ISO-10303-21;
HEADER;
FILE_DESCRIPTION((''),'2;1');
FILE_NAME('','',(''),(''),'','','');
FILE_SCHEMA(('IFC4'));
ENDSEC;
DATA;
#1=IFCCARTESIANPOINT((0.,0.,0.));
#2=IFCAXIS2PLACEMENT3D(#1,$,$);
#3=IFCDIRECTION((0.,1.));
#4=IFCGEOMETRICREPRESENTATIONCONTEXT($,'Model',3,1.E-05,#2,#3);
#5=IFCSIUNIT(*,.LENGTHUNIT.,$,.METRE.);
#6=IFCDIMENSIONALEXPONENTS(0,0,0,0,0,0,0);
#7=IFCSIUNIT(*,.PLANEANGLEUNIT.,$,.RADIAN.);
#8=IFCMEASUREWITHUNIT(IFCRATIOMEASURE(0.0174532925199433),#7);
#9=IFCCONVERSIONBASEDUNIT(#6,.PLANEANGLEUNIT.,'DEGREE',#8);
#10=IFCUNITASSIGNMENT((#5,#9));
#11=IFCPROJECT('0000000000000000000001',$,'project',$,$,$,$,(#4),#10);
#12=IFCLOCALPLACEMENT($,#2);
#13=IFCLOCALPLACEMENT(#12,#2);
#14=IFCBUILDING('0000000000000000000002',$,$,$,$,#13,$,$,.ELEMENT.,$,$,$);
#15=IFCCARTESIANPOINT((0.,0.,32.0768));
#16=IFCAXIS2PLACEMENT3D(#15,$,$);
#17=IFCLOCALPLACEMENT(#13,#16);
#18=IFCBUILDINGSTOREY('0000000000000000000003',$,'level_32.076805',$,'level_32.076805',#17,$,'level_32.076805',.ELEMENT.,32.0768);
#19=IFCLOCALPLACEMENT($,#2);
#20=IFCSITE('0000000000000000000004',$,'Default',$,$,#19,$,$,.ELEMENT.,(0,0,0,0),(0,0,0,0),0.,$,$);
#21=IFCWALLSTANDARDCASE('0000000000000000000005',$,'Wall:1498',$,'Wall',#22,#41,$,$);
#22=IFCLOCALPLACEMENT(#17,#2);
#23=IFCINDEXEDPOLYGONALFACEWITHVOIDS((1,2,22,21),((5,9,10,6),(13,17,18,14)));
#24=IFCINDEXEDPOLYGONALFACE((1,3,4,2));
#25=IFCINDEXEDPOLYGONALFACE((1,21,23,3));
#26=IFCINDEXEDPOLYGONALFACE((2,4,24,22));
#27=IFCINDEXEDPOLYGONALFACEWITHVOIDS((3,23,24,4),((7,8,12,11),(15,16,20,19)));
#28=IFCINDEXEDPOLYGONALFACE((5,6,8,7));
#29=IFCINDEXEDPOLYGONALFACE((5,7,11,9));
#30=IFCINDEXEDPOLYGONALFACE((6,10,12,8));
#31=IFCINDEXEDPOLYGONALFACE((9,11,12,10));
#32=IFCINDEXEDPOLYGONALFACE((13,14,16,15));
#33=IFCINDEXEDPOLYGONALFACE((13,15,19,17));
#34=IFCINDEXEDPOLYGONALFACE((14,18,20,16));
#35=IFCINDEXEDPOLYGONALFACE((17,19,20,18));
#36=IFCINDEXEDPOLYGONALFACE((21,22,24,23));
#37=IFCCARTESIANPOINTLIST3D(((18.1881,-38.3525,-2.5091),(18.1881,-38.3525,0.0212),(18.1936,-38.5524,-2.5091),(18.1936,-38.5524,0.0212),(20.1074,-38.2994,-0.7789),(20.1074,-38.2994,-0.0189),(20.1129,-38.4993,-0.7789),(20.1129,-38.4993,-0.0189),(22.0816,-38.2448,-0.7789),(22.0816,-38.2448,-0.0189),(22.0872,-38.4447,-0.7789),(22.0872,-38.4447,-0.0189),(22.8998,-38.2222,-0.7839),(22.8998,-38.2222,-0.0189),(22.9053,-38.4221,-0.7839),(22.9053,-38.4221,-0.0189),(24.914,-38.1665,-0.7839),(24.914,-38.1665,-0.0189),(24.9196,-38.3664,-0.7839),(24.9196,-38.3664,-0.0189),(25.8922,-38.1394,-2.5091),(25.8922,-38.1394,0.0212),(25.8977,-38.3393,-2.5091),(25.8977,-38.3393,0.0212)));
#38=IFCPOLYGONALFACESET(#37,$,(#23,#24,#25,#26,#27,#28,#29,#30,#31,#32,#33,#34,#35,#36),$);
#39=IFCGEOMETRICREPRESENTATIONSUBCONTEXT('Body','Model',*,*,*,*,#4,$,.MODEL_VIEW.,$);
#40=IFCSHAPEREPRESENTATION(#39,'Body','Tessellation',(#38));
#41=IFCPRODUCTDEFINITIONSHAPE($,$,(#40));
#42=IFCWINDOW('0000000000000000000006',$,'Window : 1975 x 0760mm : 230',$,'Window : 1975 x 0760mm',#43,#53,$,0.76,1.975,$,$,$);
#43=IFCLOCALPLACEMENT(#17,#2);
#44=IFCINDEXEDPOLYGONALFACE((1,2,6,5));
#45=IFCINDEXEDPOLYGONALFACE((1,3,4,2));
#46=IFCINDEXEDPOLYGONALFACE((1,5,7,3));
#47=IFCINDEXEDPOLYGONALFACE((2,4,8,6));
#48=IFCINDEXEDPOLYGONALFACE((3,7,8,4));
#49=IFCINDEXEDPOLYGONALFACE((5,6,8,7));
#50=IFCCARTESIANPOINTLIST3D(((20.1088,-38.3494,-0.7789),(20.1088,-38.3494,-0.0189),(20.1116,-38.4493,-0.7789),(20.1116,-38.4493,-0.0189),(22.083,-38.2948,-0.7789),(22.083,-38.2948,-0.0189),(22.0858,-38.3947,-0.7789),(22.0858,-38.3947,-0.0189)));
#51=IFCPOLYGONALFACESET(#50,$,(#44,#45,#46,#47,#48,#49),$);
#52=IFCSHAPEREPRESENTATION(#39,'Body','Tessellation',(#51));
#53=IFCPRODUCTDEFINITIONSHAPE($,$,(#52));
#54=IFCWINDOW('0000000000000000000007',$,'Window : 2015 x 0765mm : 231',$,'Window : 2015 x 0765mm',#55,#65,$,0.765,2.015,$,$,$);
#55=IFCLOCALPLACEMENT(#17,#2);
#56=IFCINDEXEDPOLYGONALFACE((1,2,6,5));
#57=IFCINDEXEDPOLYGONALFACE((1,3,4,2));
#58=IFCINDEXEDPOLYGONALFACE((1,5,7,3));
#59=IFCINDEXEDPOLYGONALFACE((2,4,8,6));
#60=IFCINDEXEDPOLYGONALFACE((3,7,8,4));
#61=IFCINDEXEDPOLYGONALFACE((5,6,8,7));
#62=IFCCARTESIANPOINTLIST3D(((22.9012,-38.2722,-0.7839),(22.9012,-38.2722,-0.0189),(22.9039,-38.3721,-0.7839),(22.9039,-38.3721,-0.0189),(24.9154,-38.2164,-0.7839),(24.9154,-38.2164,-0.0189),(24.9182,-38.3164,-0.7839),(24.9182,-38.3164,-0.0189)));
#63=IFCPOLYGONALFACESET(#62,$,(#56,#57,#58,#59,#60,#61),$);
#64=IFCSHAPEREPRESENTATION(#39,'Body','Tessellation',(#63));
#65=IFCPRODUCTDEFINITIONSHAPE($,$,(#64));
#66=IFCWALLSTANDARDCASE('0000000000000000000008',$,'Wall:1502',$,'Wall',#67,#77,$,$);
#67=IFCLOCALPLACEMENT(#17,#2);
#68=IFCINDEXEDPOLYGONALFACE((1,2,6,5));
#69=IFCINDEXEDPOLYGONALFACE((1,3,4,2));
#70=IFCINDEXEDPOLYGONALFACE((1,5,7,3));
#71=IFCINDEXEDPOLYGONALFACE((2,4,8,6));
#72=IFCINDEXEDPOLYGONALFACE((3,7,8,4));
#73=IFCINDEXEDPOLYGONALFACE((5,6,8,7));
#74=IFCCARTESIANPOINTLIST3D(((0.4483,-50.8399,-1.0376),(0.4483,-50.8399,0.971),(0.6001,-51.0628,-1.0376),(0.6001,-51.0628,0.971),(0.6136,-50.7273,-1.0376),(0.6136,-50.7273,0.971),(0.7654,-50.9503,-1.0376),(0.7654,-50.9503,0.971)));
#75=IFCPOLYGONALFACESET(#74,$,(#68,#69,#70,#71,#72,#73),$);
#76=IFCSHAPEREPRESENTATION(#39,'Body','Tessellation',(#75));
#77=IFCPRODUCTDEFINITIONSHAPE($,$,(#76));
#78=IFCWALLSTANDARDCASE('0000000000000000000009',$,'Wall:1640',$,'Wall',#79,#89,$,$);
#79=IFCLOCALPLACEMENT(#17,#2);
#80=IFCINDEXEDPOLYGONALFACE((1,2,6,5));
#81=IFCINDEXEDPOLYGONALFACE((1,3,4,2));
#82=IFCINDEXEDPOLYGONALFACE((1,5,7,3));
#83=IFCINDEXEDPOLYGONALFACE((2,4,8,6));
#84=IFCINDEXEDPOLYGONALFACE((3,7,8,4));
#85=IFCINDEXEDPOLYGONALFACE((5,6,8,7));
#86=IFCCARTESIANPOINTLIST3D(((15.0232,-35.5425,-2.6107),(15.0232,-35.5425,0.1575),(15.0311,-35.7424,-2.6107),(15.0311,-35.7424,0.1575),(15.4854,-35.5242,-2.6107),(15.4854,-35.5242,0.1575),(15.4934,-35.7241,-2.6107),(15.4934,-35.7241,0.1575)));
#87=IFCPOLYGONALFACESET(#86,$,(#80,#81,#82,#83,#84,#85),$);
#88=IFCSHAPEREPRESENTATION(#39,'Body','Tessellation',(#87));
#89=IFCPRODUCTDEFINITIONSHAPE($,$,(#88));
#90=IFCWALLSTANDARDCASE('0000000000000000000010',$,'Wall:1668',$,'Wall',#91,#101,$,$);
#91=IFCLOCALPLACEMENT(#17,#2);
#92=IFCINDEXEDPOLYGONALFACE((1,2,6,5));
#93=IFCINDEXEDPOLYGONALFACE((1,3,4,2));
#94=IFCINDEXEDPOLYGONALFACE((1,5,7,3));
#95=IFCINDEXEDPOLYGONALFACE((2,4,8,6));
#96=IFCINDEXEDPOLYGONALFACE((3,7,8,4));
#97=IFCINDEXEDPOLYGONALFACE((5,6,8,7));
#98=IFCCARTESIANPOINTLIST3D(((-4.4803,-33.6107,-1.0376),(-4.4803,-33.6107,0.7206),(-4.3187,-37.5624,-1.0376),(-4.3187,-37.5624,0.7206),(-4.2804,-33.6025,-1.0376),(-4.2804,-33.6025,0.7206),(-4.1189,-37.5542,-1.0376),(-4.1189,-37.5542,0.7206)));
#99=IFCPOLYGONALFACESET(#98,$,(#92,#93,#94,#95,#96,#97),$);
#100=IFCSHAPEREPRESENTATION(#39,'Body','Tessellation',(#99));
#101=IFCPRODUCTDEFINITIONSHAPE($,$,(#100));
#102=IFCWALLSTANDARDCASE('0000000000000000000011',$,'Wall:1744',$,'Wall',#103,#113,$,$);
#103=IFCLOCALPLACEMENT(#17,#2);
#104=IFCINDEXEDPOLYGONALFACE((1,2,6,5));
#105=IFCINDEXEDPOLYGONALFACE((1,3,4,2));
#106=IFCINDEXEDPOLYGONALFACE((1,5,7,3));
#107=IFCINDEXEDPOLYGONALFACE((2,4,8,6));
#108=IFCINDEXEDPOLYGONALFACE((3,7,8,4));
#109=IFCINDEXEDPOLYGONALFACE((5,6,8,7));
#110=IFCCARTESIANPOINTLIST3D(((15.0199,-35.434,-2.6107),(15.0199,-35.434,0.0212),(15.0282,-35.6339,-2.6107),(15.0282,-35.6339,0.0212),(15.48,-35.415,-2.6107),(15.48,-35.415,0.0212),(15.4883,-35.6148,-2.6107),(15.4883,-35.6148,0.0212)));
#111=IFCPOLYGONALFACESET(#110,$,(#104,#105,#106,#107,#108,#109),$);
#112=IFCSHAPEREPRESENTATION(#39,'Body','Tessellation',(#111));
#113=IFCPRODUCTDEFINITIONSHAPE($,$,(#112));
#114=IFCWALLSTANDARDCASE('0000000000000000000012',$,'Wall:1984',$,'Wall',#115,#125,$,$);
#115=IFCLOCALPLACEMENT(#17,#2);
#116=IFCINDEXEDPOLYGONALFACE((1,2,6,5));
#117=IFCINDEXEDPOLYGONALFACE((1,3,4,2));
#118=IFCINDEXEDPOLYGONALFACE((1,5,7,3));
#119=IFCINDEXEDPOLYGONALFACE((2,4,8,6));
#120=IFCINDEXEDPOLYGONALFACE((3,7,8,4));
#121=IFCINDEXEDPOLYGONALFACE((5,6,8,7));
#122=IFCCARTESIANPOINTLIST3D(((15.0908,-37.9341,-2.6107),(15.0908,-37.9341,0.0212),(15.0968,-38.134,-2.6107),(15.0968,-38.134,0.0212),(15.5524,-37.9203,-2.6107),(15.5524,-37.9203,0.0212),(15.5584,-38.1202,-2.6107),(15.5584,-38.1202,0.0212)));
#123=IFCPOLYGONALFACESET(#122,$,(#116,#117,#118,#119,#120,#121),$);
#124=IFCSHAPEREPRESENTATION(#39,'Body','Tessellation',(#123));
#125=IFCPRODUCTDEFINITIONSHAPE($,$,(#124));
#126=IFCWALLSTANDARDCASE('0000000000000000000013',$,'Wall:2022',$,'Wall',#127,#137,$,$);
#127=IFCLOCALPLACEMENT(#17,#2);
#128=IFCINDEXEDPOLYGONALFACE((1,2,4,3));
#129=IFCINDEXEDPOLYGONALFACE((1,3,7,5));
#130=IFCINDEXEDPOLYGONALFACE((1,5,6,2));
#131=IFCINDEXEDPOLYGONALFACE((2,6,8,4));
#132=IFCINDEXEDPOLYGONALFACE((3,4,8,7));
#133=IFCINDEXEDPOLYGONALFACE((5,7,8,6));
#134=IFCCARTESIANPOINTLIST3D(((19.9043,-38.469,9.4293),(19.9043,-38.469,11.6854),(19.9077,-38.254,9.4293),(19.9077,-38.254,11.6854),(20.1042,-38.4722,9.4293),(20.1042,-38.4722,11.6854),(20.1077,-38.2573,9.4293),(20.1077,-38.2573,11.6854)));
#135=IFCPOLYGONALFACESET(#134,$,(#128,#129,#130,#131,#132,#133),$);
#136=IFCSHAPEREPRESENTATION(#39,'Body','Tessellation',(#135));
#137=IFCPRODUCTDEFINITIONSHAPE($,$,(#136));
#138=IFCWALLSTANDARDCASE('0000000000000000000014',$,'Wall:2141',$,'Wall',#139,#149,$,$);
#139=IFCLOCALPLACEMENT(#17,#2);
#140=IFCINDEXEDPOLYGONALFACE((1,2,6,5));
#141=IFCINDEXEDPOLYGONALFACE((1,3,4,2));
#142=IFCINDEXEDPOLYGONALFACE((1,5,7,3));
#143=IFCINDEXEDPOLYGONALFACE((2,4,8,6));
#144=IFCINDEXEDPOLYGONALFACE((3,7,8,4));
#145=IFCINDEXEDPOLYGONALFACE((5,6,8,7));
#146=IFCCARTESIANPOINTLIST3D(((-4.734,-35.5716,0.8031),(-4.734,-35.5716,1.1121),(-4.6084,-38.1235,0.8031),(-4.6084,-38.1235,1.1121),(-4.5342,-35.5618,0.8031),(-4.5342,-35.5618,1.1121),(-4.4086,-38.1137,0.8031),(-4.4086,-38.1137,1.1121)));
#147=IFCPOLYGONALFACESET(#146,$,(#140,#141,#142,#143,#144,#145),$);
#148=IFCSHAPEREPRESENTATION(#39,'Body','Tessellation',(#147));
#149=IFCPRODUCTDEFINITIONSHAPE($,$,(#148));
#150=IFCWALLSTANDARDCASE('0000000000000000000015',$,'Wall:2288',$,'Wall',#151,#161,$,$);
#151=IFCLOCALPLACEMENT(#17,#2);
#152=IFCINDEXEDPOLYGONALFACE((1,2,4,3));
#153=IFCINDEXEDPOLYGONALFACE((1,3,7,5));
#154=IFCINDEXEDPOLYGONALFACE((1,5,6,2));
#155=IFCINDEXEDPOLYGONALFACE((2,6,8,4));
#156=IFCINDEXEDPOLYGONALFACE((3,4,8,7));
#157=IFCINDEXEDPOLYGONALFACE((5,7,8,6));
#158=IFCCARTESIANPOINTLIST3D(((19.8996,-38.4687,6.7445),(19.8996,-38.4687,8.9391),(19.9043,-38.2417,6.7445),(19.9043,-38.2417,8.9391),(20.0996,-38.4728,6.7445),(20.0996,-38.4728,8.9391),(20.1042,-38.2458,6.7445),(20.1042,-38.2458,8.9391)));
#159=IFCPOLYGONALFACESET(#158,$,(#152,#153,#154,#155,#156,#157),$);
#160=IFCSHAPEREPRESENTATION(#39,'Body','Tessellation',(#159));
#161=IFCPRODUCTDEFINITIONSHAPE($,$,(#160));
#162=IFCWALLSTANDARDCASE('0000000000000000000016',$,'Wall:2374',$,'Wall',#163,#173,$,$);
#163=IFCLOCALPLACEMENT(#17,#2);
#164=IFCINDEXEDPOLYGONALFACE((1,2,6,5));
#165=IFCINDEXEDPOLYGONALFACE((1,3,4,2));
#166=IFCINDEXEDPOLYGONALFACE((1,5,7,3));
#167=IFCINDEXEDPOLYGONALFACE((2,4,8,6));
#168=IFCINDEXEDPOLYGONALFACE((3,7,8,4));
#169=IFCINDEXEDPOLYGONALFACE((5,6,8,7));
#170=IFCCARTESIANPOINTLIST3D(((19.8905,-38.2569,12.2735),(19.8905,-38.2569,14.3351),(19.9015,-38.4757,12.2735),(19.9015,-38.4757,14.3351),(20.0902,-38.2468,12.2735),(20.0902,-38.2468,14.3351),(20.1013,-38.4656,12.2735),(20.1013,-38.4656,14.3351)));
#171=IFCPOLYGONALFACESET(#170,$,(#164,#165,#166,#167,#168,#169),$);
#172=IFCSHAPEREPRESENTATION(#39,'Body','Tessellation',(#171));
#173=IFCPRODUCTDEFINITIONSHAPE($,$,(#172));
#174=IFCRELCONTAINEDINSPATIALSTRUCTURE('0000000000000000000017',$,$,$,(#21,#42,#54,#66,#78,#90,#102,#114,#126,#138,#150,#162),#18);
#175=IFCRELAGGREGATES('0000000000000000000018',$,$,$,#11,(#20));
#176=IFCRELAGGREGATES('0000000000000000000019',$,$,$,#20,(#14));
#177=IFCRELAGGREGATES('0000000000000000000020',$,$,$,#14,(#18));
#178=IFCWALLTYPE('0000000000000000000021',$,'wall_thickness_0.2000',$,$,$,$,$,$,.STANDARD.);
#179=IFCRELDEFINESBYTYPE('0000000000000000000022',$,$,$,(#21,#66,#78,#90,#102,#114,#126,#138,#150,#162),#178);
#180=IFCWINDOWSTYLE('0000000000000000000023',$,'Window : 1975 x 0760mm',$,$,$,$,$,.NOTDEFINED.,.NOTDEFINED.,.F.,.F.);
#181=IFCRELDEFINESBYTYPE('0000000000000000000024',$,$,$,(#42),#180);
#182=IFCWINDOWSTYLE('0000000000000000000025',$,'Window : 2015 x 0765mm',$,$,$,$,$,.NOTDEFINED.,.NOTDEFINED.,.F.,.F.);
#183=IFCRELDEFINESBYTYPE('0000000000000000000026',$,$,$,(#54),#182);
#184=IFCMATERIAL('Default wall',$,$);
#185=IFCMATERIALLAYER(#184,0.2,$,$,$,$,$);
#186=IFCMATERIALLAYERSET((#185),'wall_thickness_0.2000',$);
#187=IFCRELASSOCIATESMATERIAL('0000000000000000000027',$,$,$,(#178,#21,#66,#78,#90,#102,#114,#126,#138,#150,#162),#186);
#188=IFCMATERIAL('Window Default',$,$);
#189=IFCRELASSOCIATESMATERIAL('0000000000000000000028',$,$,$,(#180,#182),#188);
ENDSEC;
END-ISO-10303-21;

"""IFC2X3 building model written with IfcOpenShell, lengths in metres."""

from ifc_helpers import new_model, entity, si_unit, converted_unit, direction, frame, frame_2d, origin, origin_2d_with_axis, place, context, subcontext, project, spatial, polyline, rectangle, outline, extrude, source, transform, mapped, material, layer, layer_set, layer_usage, type_object, type_shapes, element, fill, save


model = new_model("IFC2X3")

# Units and contexts
model_context = context("Model", 3, precision=1e-05, world=origin(), true_north=direction((0.0, 1.0)))
body_context = subcontext(model_context, "Body", "Model", "MODEL_VIEW")
ifc_project = project(units=[si_unit("LENGTHUNIT", "METRE"), converted_unit("PLANEANGLEUNIT", "DEGREE", entity("IfcRatioMeasure", 0.0174532925199433), si_unit("PLANEANGLEUNIT", "RADIAN"), dimensions=[0, 0, 0, 0, 0, 0, 0])], contexts=[model_context])

# Site, building, storey
site_placement = place(None, origin())
site = spatial("IfcSite", under=ifc_project, at=site_placement, Name="Default", CompositionType="ELEMENT", RefLatitude=(0, 0, 0, 0), RefLongitude=(0, 0, 0, 0), RefElevation=0.0)
placement_1 = place(None, origin())
building_placement = place(placement_1, origin())
building = spatial("IfcBuilding", under=site, at=building_placement, CompositionType="ELEMENT")
storey_placement = place(building_placement, frame((0.0, 0.0, 32.0768)))
storey = spatial("IfcBuildingStorey", under=building, at=storey_placement, Name="level_32.076805", ObjectType="level_32.076805", LongName="level_32.076805", CompositionType="ELEMENT", Elevation=32.0768)

# Shared definitions
ifc_material_1 = material(Name="Default wall")
ifc_layer = layer(ifc_material_1, 0.2)
ifc_layer_set = layer_set([ifc_layer], Name="wall_thickness_0.2000")
ifc_layer_usage = layer_usage(ifc_layer_set, "AXIS2", "POSITIVE", -0.1)
wall_type = type_object("IfcWallType", Name="wall_thickness_0.2000", PredefinedType="STANDARD", material=ifc_layer_set)

# Shared definitions
ifc_material_2 = material(Name="Window Default")

# Wall, openings, windows
placement_2 = place(building_placement, frame((0.0, 0.0, 29.5677)))
wall_1_placement = place(placement_2, frame((18.1909, -38.4525, 0.0), z_axis=(0.0, 0.0, 1.0), x_axis=(0.999618, 0.027649, 0.0)))
wall_1 = element("IfcWallStandardCase", 1, at=wall_1_placement, inside=storey, type_object=wall_type, material=ifc_layer_usage, Name="Wall:1498", ObjectType="Wall", context=body_context, shape_type="SweptSolid", body=[
    extrude(outline(polyline([(7.707, -0.1), (7.707, 0.1), (0.0, 0.1), (0.0, -0.1), (7.707, -0.1)])), origin(), (0.0, 0.0, 1.0), 2.5303),
])
opening_1_placement = place(wall_1_placement, frame((1.92, -0.1, 1.7302)))
opening_1 = element("IfcOpeningElement", 2, at=opening_1_placement, cuts=wall_1, ObjectType="Opening", context=body_context, shape_type="SweptSolid", body=[
    extrude(rectangle(XDim=1.975, YDim=0.76, at=frame_2d((0.38, 0.9875), x_axis=(0.0, 1.0))), frame((0.0, 0.0, 0.0), z_axis=(0.0, 1.0, 0.0), x_axis=(0.0, 0.0, 1.0)), (0.0, 0.0, 1.0), 0.2),
])
opening_2_placement = place(wall_1_placement, frame((4.7135, -0.1, 1.7252)))
opening_2 = element("IfcOpeningElement", 3, at=opening_2_placement, cuts=wall_1, ObjectType="Opening", context=body_context, shape_type="SweptSolid", body=[
    extrude(rectangle(XDim=2.015, YDim=0.765, at=frame_2d((0.3825, 1.0075), x_axis=(0.0, 1.0))), frame((0.0, 0.0, 0.0), z_axis=(0.0, 1.0, 0.0), x_axis=(0.0, 0.0, 1.0)), (0.0, 0.0, 1.0), 0.2),
])
window_style_1 = type_object("IfcWindowStyle", Name="Window : 1975 x 0760mm", ConstructionType="NOTDEFINED", OperationType="NOTDEFINED", ParameterTakesPrecedence=False, Sizeable=False, material=ifc_material_2)
shared_shape_1 = source(origin(), body_context, "Body", "SweptSolid", [
    extrude(rectangle(XDim=0.1, YDim=1.975, at=origin_2d_with_axis()), frame((0.9875, 0.1, 0.0), z_axis=(0.0, 0.0, 1.0), x_axis=(0.0, 1.0, 0.0)), (0.0, 0.0, 1.0), 0.76),
])
type_shapes(window_style_1, [shared_shape_1])
window_1_placement = place(opening_1_placement, origin())
window_1 = element("IfcWindow", 4, at=window_1_placement, inside=storey, type_object=window_style_1, Name="Window : 1975 x 0760mm : 230", ObjectType="Window : 1975 x 0760mm", OverallHeight=0.76, OverallWidth=1.975, context=body_context, shape_type="MappedRepresentation", body=[
    mapped(shared_shape_1, transform((0.0, 0.0, 0.0), scale=1.0)),
])
fill(opening_1, window_1)
window_style_2 = type_object("IfcWindowStyle", Name="Window : 2015 x 0765mm", ConstructionType="NOTDEFINED", OperationType="NOTDEFINED", ParameterTakesPrecedence=False, Sizeable=False, material=ifc_material_2)
shared_shape_2 = source(origin(), body_context, "Body", "SweptSolid", [
    extrude(rectangle(XDim=0.1, YDim=2.015, at=origin_2d_with_axis()), frame((1.0075, 0.1, 0.0), z_axis=(0.0, 0.0, 1.0), x_axis=(0.0, 1.0, 0.0)), (0.0, 0.0, 1.0), 0.765),
])
type_shapes(window_style_2, [shared_shape_2])
window_2_placement = place(opening_2_placement, origin())
window_2 = element("IfcWindow", 5, at=window_2_placement, inside=storey, type_object=window_style_2, Name="Window : 2015 x 0765mm : 231", ObjectType="Window : 2015 x 0765mm", OverallHeight=0.765, OverallWidth=2.015, context=body_context, shape_type="MappedRepresentation", body=[
    mapped(shared_shape_2, transform((0.0, 0.0, 0.0), scale=1.0)),
])
fill(opening_2, window_2)

# Walls
placement_3 = place(building_placement, frame((0.0, 0.0, 31.0392)))
wall_2_placement = place(placement_3, frame((0.531, -50.7836, 0.0), z_axis=(0.0, 0.0, 1.0), x_axis=(0.562651, -0.826694, 0.0)))
element("IfcWallStandardCase", 6, at=wall_2_placement, inside=storey, type_object=wall_type, material=ifc_layer_usage, Name="Wall:1502", ObjectType="Wall", context=body_context, shape_type="SweptSolid", body=[
    extrude(outline(polyline([(0.2697, -0.1), (0.2697, 0.1), (0.0, 0.1), (0.0, -0.1), (0.2697, -0.1)])), origin(), (0.0, 0.0, 1.0), 2.0086),
])
placement_4 = place(building_placement, frame((0.0, 0.0, 29.4661)))
wall_3_placement = place(placement_4, frame((15.4894, -35.6241, 0.0), z_axis=(0.0, 0.0, 1.0), x_axis=(-0.999217, -0.039552, 0.0)))
element("IfcWallStandardCase", 7, at=wall_3_placement, inside=storey, type_object=wall_type, material=ifc_layer_usage, Name="Wall:1640", ObjectType="Wall", context=body_context, shape_type="SweptSolid", body=[
    extrude(outline(polyline([(0.4627, -0.1), (0.4627, 0.1), (0.0, 0.1), (0.0, -0.1), (0.4627, -0.1)])), origin(), (0.0, 0.0, 1.0), 2.7682),
])
placement_5 = place(building_placement, frame((0.0, 0.0, 31.0392)))
wall_4_placement = place(placement_5, frame((-4.2188, -37.5583, 0.0), z_axis=(0.0, 0.0, 1.0), x_axis=(-0.040856, 0.999165, 0.0)))
element("IfcWallStandardCase", 8, at=wall_4_placement, inside=storey, type_object=wall_type, material=ifc_layer_usage, Name="Wall:1668", ObjectType="Wall", context=body_context, shape_type="SweptSolid", body=[
    extrude(outline(polyline([(3.955, -0.1), (3.955, 0.1), (0.0, 0.1), (0.0, -0.1), (3.955, -0.1)])), origin(), (0.0, 0.0, 1.0), 1.7582),
])
placement_6 = place(building_placement, frame((0.0, 0.0, 29.4661)))
wall_5_placement = place(placement_6, frame((15.4842, -35.5149, 0.0), z_axis=(0.0, 0.0, 1.0), x_axis=(-0.99914, -0.041453, 0.0)))
element("IfcWallStandardCase", 9, at=wall_5_placement, inside=storey, type_object=wall_type, material=ifc_layer_usage, Name="Wall:1744", ObjectType="Wall", context=body_context, shape_type="SweptSolid", body=[
    extrude(outline(polyline([(0.4605, -0.1), (0.4605, 0.1), (0.0, 0.1), (0.0, -0.1), (0.4605, -0.1)])), origin(), (0.0, 0.0, 1.0), 2.632),
])
placement_7 = place(building_placement, frame((0.0, 0.0, 29.4661)))
wall_6_placement = place(placement_7, frame((15.5554, -38.0203, 0.0), z_axis=(0.0, 0.0, 1.0), x_axis=(-0.999555, -0.029828, 0.0)))
element("IfcWallStandardCase", 10, at=wall_6_placement, inside=storey, type_object=wall_type, material=ifc_layer_usage, Name="Wall:1984", ObjectType="Wall", context=body_context, shape_type="SweptSolid", body=[
    extrude(outline(polyline([(0.4618, -0.1), (0.4618, 0.1), (0.0, 0.1), (0.0, -0.1), (0.4618, -0.1)])), origin(), (0.0, 0.0, 1.0), 2.632),
])
placement_8 = place(building_placement, frame((0.0, 0.0, 41.5061)))
wall_7_placement = place(placement_8, frame((20.0042, -38.4706, 0.0), z_axis=(0.0, 0.0, 1.0), x_axis=(0.016174, 0.999869, 0.0)))
element("IfcWallStandardCase", 11, at=wall_7_placement, inside=storey, type_object=wall_type, material=ifc_layer_usage, Name="Wall:2022", ObjectType="Wall", context=body_context, shape_type="SweptSolid", body=[
    extrude(outline(polyline([(0.215, -0.1), (0.215, 0.1), (0.0, 0.1), (0.0, -0.1), (0.215, -0.1)])), origin(), (0.0, 0.0, 1.0), 2.2561),
])
placement_9 = place(building_placement, frame((0.0, 0.0, 32.8799)))
wall_8_placement = place(placement_9, frame((-4.6341, -35.5667, 0.0), z_axis=(0.0, 0.0, 1.0), x_axis=(0.049156, -0.998791, 0.0)))
element("IfcWallStandardCase", 12, at=wall_8_placement, inside=storey, type_object=wall_type, material=ifc_layer_usage, Name="Wall:2141", ObjectType="Wall", context=body_context, shape_type="SweptSolid", body=[
    extrude(outline(polyline([(2.555, -0.1), (2.555, 0.1), (0.0, 0.1), (0.0, -0.1), (2.555, -0.1)])), origin(), (0.0, 0.0, 1.0), 0.309),
])
placement_10 = place(building_placement, frame((0.0, 0.0, 38.8213)))
wall_9_placement = place(placement_10, frame((20.0042, -38.2438, 0.0), z_axis=(0.0, 0.0, 1.0), x_axis=(-0.020426, -0.999791, 0.0)))
element("IfcWallStandardCase", 13, at=wall_9_placement, inside=storey, type_object=wall_type, material=ifc_layer_usage, Name="Wall:2288", ObjectType="Wall", context=body_context, shape_type="SweptSolid", body=[
    extrude(outline(polyline([(0.227, -0.1), (0.227, 0.1), (0.0, 0.1), (0.0, -0.1), (0.227, -0.1)])), origin(), (0.0, 0.0, 1.0), 2.1946),
])
placement_11 = place(building_placement, frame((0.0, 0.0, 44.3503)))
wall_10_placement = place(placement_11, frame((20.0014, -38.4707, 0.0), z_axis=(0.0, 0.0, 1.0), x_axis=(-0.050455, 0.998726, 0.0)))
element("IfcWallStandardCase", 14, at=wall_10_placement, inside=storey, type_object=wall_type, material=ifc_layer_usage, Name="Wall:2374", ObjectType="Wall", context=body_context, shape_type="SweptSolid", body=[
    extrude(outline(polyline([(0.2191, -0.1), (0.2191, 0.1), (0.0, 0.1), (0.0, -0.1), (0.2191, -0.1)])), origin(), (0.0, 0.0, 1.0), 2.0616),
])

save(model, "model.ifc")
